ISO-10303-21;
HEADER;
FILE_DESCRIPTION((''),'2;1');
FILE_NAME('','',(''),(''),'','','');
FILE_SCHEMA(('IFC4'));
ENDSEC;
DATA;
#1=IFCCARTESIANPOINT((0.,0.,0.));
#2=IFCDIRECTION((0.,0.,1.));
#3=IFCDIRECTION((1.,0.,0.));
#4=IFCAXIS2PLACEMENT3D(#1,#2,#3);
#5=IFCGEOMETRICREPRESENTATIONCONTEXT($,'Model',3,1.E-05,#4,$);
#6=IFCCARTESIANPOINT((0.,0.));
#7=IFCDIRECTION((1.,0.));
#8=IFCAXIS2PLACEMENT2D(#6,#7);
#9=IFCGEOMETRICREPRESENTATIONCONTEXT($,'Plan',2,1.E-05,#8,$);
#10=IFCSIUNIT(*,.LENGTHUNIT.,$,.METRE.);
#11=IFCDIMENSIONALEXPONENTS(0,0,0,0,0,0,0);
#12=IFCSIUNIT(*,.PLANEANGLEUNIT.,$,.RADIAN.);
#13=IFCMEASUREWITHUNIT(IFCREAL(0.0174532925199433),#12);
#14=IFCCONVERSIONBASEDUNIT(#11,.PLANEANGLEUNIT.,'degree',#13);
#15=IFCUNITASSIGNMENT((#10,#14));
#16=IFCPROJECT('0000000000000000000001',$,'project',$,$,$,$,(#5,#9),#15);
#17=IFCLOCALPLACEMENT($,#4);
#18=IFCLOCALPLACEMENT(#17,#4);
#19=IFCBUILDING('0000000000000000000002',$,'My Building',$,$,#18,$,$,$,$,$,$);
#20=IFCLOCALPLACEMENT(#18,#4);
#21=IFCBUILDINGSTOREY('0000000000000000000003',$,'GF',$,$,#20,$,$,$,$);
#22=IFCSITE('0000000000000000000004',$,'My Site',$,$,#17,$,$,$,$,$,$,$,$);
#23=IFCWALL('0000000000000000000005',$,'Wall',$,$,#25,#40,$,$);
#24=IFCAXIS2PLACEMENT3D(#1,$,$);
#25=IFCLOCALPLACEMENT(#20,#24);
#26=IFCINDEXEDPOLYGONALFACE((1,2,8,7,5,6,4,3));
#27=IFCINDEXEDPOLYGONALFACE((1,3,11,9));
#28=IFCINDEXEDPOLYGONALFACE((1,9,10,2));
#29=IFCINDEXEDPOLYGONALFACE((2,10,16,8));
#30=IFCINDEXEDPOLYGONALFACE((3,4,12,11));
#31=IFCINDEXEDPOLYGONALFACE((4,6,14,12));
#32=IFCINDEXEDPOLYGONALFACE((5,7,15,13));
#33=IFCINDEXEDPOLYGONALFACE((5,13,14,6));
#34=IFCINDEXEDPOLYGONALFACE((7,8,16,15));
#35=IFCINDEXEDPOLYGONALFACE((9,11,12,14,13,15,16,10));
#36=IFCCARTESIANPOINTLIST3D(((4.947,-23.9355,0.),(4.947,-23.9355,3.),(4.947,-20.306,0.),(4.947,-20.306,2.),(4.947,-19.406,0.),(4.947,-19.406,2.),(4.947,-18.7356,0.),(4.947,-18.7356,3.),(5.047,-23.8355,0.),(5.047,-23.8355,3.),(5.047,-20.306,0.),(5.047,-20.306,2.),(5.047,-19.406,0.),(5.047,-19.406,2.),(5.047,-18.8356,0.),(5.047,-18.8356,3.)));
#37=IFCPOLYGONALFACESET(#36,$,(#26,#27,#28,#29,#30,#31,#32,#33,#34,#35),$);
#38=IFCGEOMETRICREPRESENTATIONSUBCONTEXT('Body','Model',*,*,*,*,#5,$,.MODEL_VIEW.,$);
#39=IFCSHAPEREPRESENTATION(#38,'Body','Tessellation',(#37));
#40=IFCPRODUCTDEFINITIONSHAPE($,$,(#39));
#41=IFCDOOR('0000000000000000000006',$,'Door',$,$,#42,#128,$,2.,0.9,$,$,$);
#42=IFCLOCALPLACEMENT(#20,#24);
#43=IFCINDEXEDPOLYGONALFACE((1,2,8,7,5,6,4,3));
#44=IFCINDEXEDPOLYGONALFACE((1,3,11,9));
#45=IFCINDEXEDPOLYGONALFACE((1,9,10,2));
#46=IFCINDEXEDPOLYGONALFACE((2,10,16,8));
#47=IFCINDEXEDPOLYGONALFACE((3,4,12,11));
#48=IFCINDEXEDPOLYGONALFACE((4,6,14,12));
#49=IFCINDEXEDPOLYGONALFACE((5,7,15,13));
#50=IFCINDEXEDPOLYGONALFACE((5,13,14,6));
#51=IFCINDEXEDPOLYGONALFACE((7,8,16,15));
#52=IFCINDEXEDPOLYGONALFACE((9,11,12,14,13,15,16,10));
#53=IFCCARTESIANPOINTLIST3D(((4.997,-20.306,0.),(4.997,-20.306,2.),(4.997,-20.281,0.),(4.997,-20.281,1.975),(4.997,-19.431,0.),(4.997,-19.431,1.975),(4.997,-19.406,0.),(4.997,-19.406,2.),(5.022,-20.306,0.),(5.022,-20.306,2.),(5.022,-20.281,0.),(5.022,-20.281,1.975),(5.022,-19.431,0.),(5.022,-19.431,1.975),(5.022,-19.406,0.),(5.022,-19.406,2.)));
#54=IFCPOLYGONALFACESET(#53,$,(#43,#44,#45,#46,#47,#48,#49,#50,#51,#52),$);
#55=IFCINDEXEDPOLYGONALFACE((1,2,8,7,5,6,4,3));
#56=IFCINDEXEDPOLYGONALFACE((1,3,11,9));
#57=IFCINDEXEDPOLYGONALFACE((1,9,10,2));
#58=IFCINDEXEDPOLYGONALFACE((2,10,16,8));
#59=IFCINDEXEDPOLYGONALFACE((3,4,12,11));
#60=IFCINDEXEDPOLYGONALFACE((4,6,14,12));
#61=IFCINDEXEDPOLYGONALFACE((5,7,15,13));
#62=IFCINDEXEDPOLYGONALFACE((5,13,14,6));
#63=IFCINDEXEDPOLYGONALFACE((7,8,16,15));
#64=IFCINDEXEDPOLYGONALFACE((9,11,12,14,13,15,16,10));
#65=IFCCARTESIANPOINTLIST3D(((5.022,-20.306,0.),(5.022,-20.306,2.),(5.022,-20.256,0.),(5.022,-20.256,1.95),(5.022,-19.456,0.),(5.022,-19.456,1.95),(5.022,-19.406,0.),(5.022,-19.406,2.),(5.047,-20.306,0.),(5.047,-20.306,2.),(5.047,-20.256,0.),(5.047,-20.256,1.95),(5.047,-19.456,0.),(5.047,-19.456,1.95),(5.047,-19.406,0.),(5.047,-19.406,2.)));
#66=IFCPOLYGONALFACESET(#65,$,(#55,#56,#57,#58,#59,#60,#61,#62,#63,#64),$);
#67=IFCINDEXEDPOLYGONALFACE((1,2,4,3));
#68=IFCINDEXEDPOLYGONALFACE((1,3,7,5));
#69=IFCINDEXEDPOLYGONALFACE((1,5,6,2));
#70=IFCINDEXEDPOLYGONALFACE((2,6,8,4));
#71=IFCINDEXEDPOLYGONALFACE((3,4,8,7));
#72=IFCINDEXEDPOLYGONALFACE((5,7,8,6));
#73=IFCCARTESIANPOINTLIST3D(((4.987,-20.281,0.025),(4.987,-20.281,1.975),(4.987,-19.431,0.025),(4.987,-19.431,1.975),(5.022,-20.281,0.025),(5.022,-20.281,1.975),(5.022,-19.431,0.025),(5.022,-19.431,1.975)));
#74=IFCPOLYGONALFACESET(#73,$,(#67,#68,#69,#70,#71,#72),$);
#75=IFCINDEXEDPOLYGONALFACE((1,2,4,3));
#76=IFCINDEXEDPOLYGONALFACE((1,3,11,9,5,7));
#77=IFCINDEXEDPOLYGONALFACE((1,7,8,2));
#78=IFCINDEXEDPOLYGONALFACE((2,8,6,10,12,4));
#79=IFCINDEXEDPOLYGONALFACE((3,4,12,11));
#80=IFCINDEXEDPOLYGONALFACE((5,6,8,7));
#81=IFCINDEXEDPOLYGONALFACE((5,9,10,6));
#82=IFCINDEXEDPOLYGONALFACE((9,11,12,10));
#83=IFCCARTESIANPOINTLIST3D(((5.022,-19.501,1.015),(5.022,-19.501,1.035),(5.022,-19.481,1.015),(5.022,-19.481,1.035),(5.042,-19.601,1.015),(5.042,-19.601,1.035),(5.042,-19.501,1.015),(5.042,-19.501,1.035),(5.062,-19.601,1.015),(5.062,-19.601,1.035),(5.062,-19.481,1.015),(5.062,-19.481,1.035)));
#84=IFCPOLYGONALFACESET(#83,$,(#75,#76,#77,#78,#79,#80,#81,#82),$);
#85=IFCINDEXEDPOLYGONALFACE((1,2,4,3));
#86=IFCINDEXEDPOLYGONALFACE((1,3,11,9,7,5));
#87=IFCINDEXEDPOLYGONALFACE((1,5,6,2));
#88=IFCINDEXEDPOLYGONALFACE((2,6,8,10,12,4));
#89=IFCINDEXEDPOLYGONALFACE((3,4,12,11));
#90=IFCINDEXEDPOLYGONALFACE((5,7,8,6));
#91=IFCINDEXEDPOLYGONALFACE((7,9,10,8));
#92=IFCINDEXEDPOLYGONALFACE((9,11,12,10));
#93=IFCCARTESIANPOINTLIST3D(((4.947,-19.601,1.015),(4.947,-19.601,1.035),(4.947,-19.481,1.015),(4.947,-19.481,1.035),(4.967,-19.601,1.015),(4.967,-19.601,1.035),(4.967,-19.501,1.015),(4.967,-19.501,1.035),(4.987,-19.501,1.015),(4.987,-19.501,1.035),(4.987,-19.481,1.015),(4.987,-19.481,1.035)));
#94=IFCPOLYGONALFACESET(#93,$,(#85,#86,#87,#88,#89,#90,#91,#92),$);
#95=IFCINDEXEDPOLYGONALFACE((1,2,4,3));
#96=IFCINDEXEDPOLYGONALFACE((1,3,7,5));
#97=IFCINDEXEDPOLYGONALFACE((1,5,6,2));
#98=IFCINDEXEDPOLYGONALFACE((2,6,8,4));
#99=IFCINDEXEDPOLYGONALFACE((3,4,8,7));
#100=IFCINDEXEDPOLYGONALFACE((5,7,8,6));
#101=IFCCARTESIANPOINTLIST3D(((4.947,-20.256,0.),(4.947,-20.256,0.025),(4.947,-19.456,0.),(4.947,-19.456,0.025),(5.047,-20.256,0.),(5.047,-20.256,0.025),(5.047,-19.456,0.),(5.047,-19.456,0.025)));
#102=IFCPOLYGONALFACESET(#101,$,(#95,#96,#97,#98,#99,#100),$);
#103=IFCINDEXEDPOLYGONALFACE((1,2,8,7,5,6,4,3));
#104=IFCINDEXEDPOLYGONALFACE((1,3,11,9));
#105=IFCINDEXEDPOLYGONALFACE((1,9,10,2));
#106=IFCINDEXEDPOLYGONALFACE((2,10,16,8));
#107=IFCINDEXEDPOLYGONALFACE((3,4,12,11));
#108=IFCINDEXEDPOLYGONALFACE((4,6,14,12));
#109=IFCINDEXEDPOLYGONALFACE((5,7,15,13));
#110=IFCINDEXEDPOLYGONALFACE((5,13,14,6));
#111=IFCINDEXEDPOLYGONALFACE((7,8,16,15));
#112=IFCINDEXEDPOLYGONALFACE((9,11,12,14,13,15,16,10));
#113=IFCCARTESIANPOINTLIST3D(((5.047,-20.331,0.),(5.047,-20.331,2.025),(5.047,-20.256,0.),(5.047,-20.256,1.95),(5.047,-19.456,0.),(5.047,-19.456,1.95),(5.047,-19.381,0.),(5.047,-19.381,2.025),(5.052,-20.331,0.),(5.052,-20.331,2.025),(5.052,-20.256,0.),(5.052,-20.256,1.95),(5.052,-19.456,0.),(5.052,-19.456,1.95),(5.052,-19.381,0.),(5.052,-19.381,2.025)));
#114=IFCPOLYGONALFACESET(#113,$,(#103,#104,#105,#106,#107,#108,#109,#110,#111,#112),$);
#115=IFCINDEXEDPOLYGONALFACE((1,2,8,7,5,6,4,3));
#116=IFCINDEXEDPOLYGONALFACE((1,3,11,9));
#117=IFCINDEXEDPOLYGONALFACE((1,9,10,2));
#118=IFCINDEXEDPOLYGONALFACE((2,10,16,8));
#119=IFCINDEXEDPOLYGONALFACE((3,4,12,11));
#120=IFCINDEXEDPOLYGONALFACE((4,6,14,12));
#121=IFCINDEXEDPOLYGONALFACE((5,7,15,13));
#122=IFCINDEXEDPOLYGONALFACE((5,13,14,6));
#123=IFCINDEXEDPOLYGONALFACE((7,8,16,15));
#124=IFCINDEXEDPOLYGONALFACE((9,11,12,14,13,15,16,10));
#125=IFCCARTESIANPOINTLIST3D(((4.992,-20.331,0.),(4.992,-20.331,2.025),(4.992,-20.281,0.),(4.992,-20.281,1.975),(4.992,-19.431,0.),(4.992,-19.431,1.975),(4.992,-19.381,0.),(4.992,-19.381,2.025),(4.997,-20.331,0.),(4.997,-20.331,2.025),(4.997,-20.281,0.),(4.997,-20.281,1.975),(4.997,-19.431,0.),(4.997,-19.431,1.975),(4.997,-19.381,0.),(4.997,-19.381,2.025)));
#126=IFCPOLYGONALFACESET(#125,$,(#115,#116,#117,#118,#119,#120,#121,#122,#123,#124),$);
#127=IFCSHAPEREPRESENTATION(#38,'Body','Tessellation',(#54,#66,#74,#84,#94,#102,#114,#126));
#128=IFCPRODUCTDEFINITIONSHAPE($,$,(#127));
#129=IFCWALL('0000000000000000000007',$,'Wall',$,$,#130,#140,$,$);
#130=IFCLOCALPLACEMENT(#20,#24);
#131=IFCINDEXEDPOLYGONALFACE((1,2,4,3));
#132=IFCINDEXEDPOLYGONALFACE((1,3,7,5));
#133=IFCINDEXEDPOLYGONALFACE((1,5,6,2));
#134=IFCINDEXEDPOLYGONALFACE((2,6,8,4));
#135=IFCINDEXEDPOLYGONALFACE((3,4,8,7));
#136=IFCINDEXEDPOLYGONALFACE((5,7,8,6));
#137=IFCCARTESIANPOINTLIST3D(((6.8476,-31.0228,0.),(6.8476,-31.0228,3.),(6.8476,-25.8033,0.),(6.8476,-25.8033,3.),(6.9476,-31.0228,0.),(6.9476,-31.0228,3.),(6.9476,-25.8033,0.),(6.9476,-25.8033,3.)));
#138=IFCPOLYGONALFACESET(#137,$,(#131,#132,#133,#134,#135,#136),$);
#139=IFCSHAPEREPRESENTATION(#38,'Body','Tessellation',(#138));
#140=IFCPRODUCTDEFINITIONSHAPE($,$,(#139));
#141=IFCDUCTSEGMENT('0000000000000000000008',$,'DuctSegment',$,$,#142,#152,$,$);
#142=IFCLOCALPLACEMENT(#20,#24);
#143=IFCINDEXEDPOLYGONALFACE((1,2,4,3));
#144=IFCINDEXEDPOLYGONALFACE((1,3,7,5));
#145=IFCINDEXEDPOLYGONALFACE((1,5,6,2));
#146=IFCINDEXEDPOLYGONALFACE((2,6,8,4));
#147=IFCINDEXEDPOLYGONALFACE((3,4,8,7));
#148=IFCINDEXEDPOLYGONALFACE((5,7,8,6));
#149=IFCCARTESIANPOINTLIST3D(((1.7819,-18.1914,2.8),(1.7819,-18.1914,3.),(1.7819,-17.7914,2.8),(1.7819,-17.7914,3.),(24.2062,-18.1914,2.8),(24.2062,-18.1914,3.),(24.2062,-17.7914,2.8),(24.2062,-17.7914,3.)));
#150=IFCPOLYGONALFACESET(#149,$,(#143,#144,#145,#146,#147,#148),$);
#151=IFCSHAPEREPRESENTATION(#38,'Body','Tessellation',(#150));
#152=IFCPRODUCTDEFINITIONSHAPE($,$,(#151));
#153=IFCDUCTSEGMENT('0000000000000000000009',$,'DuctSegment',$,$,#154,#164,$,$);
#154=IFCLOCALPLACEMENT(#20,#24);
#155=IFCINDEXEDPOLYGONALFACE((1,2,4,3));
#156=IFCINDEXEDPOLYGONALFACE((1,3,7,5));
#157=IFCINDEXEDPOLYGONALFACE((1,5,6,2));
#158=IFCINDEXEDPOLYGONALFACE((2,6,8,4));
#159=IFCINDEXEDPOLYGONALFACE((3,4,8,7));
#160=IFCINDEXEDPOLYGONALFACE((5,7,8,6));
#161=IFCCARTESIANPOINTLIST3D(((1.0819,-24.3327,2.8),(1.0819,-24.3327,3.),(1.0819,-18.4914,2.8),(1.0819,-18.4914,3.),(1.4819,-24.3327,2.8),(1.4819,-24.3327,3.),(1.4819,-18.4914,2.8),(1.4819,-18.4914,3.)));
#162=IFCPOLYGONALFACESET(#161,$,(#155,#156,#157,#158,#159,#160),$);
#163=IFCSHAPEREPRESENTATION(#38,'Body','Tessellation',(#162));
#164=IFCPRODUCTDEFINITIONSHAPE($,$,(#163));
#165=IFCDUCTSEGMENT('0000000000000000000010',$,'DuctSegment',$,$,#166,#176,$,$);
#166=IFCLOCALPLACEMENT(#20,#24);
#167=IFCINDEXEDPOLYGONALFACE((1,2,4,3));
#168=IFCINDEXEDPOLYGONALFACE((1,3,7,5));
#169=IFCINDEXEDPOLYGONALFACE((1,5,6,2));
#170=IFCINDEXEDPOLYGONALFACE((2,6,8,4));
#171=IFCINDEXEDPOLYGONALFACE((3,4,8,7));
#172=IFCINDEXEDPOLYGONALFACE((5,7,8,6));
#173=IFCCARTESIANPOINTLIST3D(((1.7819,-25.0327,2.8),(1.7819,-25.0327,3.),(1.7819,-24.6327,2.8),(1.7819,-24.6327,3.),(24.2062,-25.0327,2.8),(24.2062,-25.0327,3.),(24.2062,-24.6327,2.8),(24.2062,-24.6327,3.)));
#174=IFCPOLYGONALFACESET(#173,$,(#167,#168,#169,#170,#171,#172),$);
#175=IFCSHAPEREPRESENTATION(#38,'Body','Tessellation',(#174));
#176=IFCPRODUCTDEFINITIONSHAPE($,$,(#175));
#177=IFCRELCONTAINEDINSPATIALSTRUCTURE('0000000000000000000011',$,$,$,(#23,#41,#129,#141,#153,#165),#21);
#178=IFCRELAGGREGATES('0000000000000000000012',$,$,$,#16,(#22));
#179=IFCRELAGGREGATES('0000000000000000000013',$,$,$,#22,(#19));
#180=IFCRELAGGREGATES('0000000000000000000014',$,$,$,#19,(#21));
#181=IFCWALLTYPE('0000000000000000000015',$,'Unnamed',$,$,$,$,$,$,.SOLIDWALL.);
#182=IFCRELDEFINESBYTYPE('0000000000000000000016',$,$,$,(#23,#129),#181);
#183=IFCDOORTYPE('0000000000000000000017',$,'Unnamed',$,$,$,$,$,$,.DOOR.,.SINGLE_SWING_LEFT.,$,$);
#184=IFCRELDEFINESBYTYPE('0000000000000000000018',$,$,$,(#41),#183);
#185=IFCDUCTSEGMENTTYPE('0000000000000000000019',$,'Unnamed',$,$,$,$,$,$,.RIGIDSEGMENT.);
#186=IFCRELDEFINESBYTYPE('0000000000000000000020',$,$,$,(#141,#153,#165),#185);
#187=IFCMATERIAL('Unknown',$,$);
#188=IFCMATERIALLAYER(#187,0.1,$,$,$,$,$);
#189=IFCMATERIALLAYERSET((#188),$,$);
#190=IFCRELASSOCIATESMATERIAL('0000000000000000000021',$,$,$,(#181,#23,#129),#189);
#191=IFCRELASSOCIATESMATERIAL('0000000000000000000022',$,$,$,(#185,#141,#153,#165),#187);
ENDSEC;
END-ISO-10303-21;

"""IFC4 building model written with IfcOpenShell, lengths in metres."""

from ifc_helpers import new_model, entity, si_unit, converted_unit, frame, origin_with_axes, origin_2d_with_axis, place, context, subcontext, project, spatial, line, indexed_curve, rectangle, outline, extrude, shape, source, transform, mapped, material, layer, layer_set, layer_usage, material_profile, profile_set, profile_usage, type_object, type_shapes, element, fill, save


model = new_model("IFC4")

# Units and contexts
model_context = context("Model", 3, precision=1e-05, world=origin_with_axes())
plan_context = context("Plan", 2, precision=1e-05, world=origin_2d_with_axis())
body_context_1 = subcontext(model_context, "Body", "Model", "MODEL_VIEW")
body_context_2 = subcontext(plan_context, "Body", "Plan", "PLAN_VIEW")
ifc_project = project(units=[si_unit("LENGTHUNIT", "METRE"), converted_unit("PLANEANGLEUNIT", "degree", entity("IfcReal", 0.0174532925199433), si_unit("PLANEANGLEUNIT", "RADIAN"), dimensions=[0, 0, 0, 0, 0, 0, 0])], contexts=[model_context, plan_context])

# Site, building, storey
site_placement = place(None, origin_with_axes())
site = spatial("IfcSite", under=ifc_project, at=site_placement, Name="My Site")
building_placement = place(site_placement, origin_with_axes())
building = spatial("IfcBuilding", under=site, at=building_placement, Name="My Building")
storey_placement = place(building_placement, origin_with_axes())
storey = spatial("IfcBuildingStorey", under=building, at=storey_placement, Name="GF")

# Shared definitions
ifc_material = material(Name="Unknown")

# Shared definitions
ifc_layer_1 = layer(ifc_material, 0.1)
ifc_layer_set_1 = layer_set([ifc_layer_1])
wall_type = type_object("IfcWallType", Name="Unnamed", PredefinedType="SOLIDWALL", material=ifc_layer_set_1)

# Shared definitions
shared_shape_1 = source(origin_with_axes(), body_context_1, "Body", "SweptSolid", [
    extrude(outline(indexed_curve([(0.0, 0.0), (0.9, 0.0), (0.9, 2.0), (0.0, 2.0)], segments=[line(1, 2, 3, 4, 1)])), frame((0.0, -0.6, 0.0), z_axis=(0.0, -1.0, 0.0), x_axis=(1.0, 0.0, 0.0)), (0.0, 0.0, -1.0), 1.2),
])
door_type = type_object("IfcDoorType", Name="Unnamed", OperationType="SINGLE_SWING_LEFT", PredefinedType="DOOR")
shared_shape_2 = source(origin_with_axes(), body_context_1, "Body", "SweptSolid", [
    extrude(outline(indexed_curve([(0.0, 0.0), (0.0, 2.0), (0.9, 2.0), (0.9, 0.0), (0.875, 0.0), (0.875, 1.975), (0.025, 1.975), (0.025, 0.0)], segments=[line(1, 2, 3, 4, 5, 6, 7, 8, 1)])), frame((0.0, 0.025, 0.0), z_axis=(0.0, -1.0, 0.0), x_axis=(1.0, 0.0, 0.0)), (0.0, 0.0, -1.0), 0.025),
    extrude(outline(indexed_curve([(0.0, 0.0), (0.0, 2.0), (0.9, 2.0), (0.9, 0.0), (0.85, 0.0), (0.85, 1.95), (0.05, 1.95), (0.05, 0.0)], segments=[line(1, 2, 3, 4, 5, 6, 7, 8, 1)])), frame((0.0, 0.0, 0.0), z_axis=(0.0, -1.0, 0.0), x_axis=(1.0, 0.0, 0.0)), (0.0, 0.0, -1.0), 0.025),
    extrude(outline(indexed_curve([(0.0, 0.0), (0.85, 0.0), (0.85, 0.035), (0.0, 0.035)], segments=[line(1, 2, 3, 4, 1)])), frame((0.025, 0.025, 0.025), z_axis=(0.0, 0.0, 1.0), x_axis=(1.0, 0.0, 0.0)), (0.0, 0.0, 1.0), 1.95),
    extrude(outline(indexed_curve([(0.0, 0.0), (0.0, -0.04), (-0.12, -0.04), (-0.12, -0.02), (-0.02, -0.02), (-0.02, 0.0)], segments=[line(1, 2, 3, 4, 5, 6, 1)])), frame((0.825, 0.025, 1.015), z_axis=(0.0, 0.0, 1.0), x_axis=(1.0, 0.0, 0.0)), (0.0, 0.0, 1.0), 0.02),
    extrude(outline(indexed_curve([(0.0, 0.0), (0.0, 0.04), (-0.12, 0.04), (-0.12, 0.02), (-0.02, 0.02), (-0.02, 0.0)], segments=[line(1, 2, 3, 4, 5, 6, 1)])), frame((0.825, 0.06, 1.015), z_axis=(0.0, 0.0, 1.0), x_axis=(1.0, 0.0, 0.0)), (0.0, 0.0, 1.0), 0.02),
    extrude(outline(indexed_curve([(0.0, 0.0), (0.8, 0.0), (0.8, 0.1), (0.0, 0.1)], segments=[line(1, 2, 3, 4, 1)])), frame((0.05, 0.0, 0.0), z_axis=(0.0, 0.0, 1.0), x_axis=(1.0, 0.0, 0.0)), (0.0, 0.0, 1.0), 0.025),
    extrude(outline(indexed_curve([(0.0, 0.0), (0.0, 2.025), (0.95, 2.025), (0.95, 0.0), (0.875, 0.0), (0.875, 1.95), (0.075, 1.95), (0.075, 0.0)], segments=[line(1, 2, 3, 4, 5, 6, 7, 8, 1)])), frame((-0.025, -0.005, 0.0), z_axis=(0.0, -1.0, 0.0), x_axis=(1.0, 0.0, 0.0)), (0.0, 0.0, -1.0), 0.005),
    extrude(outline(indexed_curve([(0.0, 0.0), (0.0, 2.025), (0.95, 2.025), (0.95, 0.0), (0.9, 0.0), (0.9, 1.975), (0.05, 1.975), (0.05, 0.0)], segments=[line(1, 2, 3, 4, 5, 6, 7, 8, 1)])), frame((-0.025, 0.05, 0.0), z_axis=(0.0, -1.0, 0.0), x_axis=(1.0, 0.0, 0.0)), (0.0, 0.0, -1.0), 0.005),
])
shared_shape_3 = source(origin_with_axes(), body_context_2, "Body", "Curve2D", [
    entity("IfcIndexedPolyCurve", entity("IfcCartesianPointList2D", [[0.0, 0.0], [0.0, 0.05], [0.025, 0.05], [0.025, 0.025], [0.05, 0.025], [0.05, 0.0]]), [entity("IfcLineIndex", [1, 2, 3, 4, 5, 6, 1])]),
    entity("IfcIndexedPolyCurve", entity("IfcCartesianPointList2D", [[0.9, 0.0], [0.9, 0.05], [0.875, 0.05], [0.875, 0.025], [0.85, 0.025], [0.85, 0.0]]), [entity("IfcLineIndex", [1, 2, 3, 4, 5, 6, 1])]),
    entity("IfcTrimmedCurve", entity("IfcEllipse", entity("IfcAxis2Placement2D", entity("IfcCartesianPoint", [0.06, 0.05]), entity("IfcDirection", [1.0, 0.0])), 0.815, 0.85), [entity("IfcCartesianPoint", [0.875, 0.05])], [entity("IfcCartesianPoint", [0.06, 0.9])], True, "CARTESIAN"),
    entity("IfcIndexedPolyCurve", entity("IfcCartesianPointList2D", [[0.025, 0.05], [0.06, 0.05], [0.06, 0.9], [0.025, 0.9]]), [entity("IfcLineIndex", [1, 2, 3, 4, 1])]),
])
type_shapes(door_type, [shared_shape_2, shared_shape_3])

# Wall, opening, door
ifc_layer_usage_1 = layer_usage(ifc_layer_set_1, "AXIS2", "POSITIVE", 0.0)
wall_1_placement = place(storey_placement, frame((5.047, -23.8355, 0.0), z_axis=(0.0, 0.0, 1.0), x_axis=(0.0, 1.0, 0.0)))
wall_1 = element("IfcWall", 1, at=wall_1_placement, inside=storey, type_object=wall_type, material=ifc_layer_usage_1, Name="Wall", context=body_context_1, shape_type="SweptSolid", body=[
    extrude(outline(indexed_curve([(0.0, 0.0), (-0.1, 0.1), (5.1, 0.1), (5.0, 0.0)], segments=[line(1, 2, 3, 4, 1)])), origin_with_axes(), (0.0, 0.0, 1.0), 3.0),
])
opening_1_placement = place(wall_1_placement, frame((3.5295, 0.0, 0.0), z_axis=(0.0, 0.0, 1.0), x_axis=(1.0, 0.0, 0.0)))
opening_1 = element("IfcOpeningElement", 2, at=opening_1_placement, cuts=wall_1, PredefinedType="OPENING", context=body_context_1, shape_type="MappedRepresentation", body=[
    mapped(shared_shape_1, transform((0.0, 0.0, 0.0), x_axis=(1.0, 0.0, 0.0), y_axis=(0.0, 1.0, 0.0), z_axis=(0.0, 0.0, 1.0), scale=1.0)),
])
door_1_placement = place(opening_1_placement, frame((0.0, 0.0, 0.0), z_axis=(0.0, 0.0, 1.0), x_axis=(1.0, 0.0, 0.0)))
door_1 = element("IfcDoor", 3, at=door_1_placement, inside=storey, type_object=door_type, Name="Door", OverallHeight=2.0, OverallWidth=0.9, shapes=[
    shape(body_context_1, "Body", "MappedRepresentation", [mapped(shared_shape_2, transform((0.0, 0.0, 0.0), x_axis=(1.0, 0.0, 0.0), y_axis=(0.0, 1.0, 0.0), z_axis=(0.0, 0.0, 1.0), scale=1.0))]),
    shape(body_context_2, "Body", "MappedRepresentation", [mapped(shared_shape_3, transform((0.0, 0.0, 0.0), x_axis=(1.0, 0.0, 0.0), y_axis=(0.0, 1.0, 0.0), z_axis=(0.0, 0.0, 1.0), scale=1.0))]),
])
fill(opening_1, door_1)

# Wall
ifc_layer_usage_2 = layer_usage(ifc_layer_set_1, "AXIS2", "POSITIVE", 0.0)
wall_2_placement = place(storey_placement, frame((6.8476, -25.8033, 0.0), z_axis=(0.0, 0.0, 1.0), x_axis=(0.0, -1.0, 0.0)))
element("IfcWall", 4, at=wall_2_placement, inside=storey, type_object=wall_type, material=ifc_layer_usage_2, Name="Wall", context=body_context_1, shape_type="SweptSolid", body=[
    extrude(outline(indexed_curve([(0.0, 0.0), (0.0, 0.1), (5.2195, 0.1), (5.2195, 0.0)], segments=[line(1, 2, 3, 4, 1)])), origin_with_axes(), (0.0, 0.0, 1.0), 3.0),
])

# Duct segments
ifc_material_profile_1 = material_profile(ifc_material, rectangle(XDim=0.4, YDim=0.2))
ifc_profile_set_1 = profile_set([ifc_material_profile_1])
ifc_profile_usage_1 = profile_usage(ifc_profile_set_1, cardinal=5)
duct_segment_type = type_object("IfcDuctSegmentType", Name="Unnamed", PredefinedType="RIGIDSEGMENT", material=ifc_profile_set_1)
duct_segment_1_placement = place(storey_placement, frame((1.7819, -17.9914, 2.9), z_axis=(1.0, 0.0, 0.0), x_axis=(0.0, 1.0, 0.0)))
element("IfcDuctSegment", 5, at=duct_segment_1_placement, inside=storey, type_object=duct_segment_type, material=ifc_profile_usage_1, Name="DuctSegment", context=body_context_1, shape_type="SweptSolid", body=[
    extrude(rectangle(XDim=0.4, YDim=0.2), origin_with_axes(), (0.0, 0.0, 1.0), 22.4244),
])
ifc_profile_usage_2 = profile_usage(ifc_profile_set_1, cardinal=5)
duct_segment_2_placement = place(storey_placement, frame((1.2819, -18.4914, 2.9), z_axis=(0.0, -1.0, 0.0), x_axis=(1.0, 0.0, 0.0)))
element("IfcDuctSegment", 6, at=duct_segment_2_placement, inside=storey, type_object=duct_segment_type, material=ifc_profile_usage_2, Name="DuctSegment", context=body_context_1, shape_type="SweptSolid", body=[
    extrude(rectangle(XDim=0.4, YDim=0.2), origin_with_axes(), (0.0, 0.0, 1.0), 5.8413),
])
ifc_profile_usage_3 = profile_usage(ifc_profile_set_1, cardinal=5)
duct_segment_3_placement = place(storey_placement, frame((1.7819, -24.8327, 2.9), z_axis=(1.0, 0.0, 0.0), x_axis=(0.0, 1.0, 0.0)))
element("IfcDuctSegment", 7, at=duct_segment_3_placement, inside=storey, type_object=duct_segment_type, material=ifc_profile_usage_3, Name="DuctSegment", context=body_context_1, shape_type="SweptSolid", body=[
    extrude(rectangle(XDim=0.4, YDim=0.2), origin_with_axes(), (0.0, 0.0, 1.0), 22.4244),
])

save(model, "model.ifc")
